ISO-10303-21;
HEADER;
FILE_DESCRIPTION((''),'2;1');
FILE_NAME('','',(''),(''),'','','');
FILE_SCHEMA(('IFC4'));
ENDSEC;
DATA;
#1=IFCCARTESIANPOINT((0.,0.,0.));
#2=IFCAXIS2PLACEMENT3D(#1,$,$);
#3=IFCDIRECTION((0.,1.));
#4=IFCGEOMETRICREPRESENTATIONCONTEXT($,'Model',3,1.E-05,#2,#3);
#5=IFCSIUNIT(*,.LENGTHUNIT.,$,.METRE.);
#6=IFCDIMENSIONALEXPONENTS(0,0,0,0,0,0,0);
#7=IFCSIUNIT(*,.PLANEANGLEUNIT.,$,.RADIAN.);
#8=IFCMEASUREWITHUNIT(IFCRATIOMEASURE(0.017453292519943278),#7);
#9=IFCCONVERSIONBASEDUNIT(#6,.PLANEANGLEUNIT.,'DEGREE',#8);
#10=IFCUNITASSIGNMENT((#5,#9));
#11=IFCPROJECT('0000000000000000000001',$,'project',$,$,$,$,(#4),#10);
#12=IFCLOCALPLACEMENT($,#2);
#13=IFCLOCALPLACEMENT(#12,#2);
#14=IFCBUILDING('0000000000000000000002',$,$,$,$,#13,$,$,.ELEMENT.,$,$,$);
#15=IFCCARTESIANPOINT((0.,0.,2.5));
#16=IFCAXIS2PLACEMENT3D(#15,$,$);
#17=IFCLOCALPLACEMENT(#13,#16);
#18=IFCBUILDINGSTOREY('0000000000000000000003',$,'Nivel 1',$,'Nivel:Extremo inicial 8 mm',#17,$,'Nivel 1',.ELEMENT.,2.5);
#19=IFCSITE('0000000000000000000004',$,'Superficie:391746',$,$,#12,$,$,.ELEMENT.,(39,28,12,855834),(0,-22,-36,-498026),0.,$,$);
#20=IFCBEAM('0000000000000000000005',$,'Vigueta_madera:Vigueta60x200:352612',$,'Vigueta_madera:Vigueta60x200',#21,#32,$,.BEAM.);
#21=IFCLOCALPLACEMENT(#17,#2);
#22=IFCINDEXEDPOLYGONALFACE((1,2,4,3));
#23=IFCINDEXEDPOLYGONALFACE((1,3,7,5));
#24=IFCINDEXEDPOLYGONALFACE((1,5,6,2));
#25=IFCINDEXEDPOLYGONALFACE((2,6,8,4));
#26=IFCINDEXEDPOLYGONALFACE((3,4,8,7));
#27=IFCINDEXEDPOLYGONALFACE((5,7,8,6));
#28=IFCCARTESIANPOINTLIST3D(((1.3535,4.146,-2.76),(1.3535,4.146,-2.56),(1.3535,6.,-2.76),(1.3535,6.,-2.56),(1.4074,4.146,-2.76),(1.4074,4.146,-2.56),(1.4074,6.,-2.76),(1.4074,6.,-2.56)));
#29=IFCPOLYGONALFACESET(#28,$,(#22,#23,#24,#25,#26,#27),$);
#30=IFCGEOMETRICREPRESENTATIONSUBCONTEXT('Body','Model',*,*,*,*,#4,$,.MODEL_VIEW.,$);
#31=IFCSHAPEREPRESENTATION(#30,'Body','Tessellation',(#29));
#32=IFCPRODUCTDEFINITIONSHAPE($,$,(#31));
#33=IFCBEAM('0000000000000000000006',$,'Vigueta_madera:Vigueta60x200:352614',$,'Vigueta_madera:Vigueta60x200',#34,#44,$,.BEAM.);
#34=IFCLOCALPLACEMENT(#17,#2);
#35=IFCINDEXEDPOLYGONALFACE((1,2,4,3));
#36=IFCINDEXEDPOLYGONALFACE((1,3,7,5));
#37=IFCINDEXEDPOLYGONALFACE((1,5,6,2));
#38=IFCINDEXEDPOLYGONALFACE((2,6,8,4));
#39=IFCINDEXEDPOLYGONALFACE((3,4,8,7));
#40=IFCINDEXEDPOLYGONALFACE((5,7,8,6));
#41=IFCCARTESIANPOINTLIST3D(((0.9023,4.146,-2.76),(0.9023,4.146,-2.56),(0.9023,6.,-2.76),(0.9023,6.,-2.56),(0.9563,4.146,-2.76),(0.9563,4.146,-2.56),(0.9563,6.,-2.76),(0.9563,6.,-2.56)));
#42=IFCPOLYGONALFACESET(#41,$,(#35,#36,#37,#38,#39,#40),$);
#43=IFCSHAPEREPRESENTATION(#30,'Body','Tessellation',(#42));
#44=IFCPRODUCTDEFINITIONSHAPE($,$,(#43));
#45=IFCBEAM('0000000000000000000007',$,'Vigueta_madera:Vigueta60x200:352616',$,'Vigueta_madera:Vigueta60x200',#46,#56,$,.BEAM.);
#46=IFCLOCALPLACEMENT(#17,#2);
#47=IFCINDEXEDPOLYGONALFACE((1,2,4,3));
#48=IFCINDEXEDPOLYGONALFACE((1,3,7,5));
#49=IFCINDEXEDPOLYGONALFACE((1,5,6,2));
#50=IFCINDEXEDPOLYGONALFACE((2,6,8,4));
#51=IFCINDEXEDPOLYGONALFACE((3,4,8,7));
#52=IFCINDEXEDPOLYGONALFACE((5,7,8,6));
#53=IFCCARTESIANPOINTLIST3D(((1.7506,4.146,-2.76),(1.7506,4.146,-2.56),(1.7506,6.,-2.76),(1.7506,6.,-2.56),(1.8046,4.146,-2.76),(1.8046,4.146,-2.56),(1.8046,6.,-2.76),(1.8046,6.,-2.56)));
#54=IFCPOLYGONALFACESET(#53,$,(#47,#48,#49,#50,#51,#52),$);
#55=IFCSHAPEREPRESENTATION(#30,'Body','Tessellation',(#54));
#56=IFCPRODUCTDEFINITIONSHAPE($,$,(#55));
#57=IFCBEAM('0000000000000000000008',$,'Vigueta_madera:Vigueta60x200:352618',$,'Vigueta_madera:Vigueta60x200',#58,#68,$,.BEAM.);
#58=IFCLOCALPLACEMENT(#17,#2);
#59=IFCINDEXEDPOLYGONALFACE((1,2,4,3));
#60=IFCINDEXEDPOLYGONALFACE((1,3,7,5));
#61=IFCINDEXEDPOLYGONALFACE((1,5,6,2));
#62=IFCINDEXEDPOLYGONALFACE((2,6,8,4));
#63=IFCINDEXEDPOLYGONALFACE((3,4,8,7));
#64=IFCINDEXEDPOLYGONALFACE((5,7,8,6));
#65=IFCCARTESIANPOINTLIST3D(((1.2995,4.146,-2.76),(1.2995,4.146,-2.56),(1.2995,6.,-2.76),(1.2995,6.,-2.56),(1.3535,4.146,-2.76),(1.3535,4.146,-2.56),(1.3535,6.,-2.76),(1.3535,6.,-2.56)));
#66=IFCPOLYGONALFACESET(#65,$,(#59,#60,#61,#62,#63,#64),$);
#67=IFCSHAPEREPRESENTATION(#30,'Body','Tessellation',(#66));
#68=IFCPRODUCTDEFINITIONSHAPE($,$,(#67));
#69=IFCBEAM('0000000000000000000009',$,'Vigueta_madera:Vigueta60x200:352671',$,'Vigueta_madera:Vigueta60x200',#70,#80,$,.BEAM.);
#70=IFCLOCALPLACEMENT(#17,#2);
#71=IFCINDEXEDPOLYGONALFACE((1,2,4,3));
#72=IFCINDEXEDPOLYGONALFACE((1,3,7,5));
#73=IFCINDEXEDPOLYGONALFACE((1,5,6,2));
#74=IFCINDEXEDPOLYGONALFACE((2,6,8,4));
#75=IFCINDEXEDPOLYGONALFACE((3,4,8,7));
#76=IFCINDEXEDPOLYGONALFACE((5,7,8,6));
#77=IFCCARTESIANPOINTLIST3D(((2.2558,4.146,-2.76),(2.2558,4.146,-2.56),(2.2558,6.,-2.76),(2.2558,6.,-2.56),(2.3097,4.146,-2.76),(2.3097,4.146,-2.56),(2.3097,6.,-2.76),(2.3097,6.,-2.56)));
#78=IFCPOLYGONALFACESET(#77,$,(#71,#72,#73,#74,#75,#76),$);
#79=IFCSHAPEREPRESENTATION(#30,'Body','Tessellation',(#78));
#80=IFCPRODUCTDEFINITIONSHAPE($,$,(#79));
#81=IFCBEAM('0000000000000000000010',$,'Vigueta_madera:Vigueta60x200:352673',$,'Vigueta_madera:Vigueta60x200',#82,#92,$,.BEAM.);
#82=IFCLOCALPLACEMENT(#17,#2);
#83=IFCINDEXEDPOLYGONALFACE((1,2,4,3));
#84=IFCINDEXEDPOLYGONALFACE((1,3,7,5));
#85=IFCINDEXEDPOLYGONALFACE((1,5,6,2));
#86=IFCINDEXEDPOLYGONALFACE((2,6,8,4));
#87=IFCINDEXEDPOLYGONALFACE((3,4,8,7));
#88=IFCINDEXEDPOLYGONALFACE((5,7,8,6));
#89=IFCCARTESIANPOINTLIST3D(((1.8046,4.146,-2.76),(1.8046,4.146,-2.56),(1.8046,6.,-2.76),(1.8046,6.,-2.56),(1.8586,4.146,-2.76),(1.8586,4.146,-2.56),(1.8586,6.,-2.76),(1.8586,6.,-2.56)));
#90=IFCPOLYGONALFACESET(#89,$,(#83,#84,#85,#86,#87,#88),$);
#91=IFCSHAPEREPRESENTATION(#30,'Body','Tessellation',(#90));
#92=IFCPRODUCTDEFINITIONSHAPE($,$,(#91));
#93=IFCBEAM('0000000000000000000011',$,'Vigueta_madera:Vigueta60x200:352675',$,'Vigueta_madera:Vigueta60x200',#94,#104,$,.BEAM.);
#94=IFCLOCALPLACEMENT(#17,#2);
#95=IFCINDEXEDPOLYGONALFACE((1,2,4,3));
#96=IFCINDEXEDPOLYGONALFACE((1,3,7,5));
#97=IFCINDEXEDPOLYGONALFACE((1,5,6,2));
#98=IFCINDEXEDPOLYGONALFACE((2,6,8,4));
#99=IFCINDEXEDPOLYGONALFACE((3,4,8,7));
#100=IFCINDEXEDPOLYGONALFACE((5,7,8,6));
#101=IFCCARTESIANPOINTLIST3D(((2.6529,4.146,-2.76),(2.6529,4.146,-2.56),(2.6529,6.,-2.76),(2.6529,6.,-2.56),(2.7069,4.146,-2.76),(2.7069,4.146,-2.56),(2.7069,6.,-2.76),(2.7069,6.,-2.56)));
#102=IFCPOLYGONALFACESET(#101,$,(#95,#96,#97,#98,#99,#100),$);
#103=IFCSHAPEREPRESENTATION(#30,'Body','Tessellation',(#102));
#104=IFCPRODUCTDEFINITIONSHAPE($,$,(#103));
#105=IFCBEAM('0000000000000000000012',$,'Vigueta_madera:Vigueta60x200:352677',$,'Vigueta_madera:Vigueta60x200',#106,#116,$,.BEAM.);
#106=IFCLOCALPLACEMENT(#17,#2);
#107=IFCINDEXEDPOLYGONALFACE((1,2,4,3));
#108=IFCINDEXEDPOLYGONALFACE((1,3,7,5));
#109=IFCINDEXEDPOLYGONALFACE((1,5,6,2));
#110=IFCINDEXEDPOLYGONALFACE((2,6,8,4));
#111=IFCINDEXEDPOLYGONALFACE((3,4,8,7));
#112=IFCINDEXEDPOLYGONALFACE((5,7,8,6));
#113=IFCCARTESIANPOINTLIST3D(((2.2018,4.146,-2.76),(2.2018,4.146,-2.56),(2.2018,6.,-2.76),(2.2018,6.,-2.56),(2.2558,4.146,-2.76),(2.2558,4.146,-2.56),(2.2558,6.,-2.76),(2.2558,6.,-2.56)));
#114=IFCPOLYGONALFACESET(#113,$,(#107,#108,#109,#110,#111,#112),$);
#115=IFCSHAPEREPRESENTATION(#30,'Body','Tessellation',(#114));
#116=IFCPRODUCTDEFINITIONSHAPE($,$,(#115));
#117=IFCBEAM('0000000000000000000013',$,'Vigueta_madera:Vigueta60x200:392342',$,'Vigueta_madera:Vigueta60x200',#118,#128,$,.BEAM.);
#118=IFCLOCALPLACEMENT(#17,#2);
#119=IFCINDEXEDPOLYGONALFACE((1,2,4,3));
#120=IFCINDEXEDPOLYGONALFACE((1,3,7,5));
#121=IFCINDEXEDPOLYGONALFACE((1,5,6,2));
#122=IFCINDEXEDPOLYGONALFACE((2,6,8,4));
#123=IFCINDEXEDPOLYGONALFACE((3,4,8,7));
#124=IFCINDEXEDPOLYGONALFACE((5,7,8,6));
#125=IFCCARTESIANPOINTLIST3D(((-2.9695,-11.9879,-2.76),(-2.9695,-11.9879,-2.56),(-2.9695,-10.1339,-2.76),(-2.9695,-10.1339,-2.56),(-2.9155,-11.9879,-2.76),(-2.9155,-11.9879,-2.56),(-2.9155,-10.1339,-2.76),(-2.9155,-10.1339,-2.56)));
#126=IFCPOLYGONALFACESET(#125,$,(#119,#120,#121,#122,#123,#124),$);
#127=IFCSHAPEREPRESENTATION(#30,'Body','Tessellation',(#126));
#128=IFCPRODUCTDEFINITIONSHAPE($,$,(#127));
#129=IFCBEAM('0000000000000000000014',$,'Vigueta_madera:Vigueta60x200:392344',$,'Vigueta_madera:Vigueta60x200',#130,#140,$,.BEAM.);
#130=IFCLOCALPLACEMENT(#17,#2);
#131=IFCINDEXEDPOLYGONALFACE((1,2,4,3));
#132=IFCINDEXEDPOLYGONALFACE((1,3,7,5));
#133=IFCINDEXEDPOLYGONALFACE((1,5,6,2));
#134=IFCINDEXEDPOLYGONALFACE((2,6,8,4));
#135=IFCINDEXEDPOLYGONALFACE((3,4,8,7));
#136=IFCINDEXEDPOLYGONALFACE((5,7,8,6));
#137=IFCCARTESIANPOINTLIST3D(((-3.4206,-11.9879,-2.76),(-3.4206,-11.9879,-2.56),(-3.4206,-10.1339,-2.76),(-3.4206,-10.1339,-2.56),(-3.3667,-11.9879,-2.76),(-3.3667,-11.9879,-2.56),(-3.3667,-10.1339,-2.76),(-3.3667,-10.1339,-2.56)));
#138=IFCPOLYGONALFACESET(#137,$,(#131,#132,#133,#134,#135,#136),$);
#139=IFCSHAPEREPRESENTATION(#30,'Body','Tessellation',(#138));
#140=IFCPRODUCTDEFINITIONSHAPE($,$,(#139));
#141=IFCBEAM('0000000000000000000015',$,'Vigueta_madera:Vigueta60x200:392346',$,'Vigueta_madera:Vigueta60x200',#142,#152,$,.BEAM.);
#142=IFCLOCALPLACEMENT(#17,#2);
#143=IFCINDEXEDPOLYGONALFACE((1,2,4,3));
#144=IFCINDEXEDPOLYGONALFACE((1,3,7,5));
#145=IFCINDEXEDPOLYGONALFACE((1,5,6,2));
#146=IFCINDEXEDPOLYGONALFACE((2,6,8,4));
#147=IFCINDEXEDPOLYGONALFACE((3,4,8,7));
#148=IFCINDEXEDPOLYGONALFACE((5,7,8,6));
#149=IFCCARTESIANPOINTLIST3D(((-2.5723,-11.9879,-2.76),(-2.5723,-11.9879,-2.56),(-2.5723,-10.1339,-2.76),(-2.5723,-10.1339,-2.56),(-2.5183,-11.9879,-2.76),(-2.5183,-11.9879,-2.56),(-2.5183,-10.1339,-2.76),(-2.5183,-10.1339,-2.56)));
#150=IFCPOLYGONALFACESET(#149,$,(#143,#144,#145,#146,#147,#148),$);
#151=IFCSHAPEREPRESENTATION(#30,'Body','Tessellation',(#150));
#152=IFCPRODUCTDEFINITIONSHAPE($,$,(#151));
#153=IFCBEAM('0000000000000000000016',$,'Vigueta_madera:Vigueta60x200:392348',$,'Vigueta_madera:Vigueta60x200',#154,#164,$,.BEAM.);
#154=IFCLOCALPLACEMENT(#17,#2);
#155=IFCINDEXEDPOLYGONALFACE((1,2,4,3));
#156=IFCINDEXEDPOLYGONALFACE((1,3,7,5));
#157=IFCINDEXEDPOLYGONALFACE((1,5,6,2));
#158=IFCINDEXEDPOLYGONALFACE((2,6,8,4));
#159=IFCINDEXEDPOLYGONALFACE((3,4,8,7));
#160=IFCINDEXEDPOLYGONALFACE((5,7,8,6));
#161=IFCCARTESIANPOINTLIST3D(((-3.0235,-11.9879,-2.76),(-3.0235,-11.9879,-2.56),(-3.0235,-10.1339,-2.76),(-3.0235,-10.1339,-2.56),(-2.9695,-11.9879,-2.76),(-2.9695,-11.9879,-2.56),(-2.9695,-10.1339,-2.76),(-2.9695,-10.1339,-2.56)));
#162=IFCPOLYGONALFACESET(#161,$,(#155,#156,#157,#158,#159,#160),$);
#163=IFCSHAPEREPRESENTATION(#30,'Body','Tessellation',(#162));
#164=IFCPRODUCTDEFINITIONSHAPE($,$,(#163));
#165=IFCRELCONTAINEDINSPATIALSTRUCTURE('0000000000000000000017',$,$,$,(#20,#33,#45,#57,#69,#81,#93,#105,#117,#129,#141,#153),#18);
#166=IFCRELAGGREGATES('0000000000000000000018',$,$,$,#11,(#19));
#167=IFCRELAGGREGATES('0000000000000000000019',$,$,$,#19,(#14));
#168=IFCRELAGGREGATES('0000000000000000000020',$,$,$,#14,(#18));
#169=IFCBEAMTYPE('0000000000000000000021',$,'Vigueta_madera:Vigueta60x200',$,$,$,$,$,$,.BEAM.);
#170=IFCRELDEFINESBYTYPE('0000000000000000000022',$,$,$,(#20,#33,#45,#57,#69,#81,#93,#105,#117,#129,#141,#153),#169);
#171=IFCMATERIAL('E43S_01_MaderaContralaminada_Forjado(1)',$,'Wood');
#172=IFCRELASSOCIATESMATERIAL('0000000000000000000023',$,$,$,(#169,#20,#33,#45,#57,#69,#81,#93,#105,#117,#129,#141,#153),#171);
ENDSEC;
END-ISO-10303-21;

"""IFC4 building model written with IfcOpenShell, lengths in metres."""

from ifc_helpers import new_model, entity, si_unit, converted_unit, direction, frame, frame_2d, origin, place, context, subcontext, project, spatial, polyline, segment, composite_curve, rectangle, outline, extrude, source, transform, mapped, material, material_profile, profile_set, profile_usage, type_object, type_shapes, element, save


model = new_model("IFC4")

# Units and contexts
model_context = context("Model", 3, precision=1e-05, world=origin(), true_north=direction((0.0, 1.0)))
body_context = subcontext(model_context, "Body", "Model", "MODEL_VIEW")
ifc_project = project(units=[si_unit("LENGTHUNIT", "METRE"), converted_unit("PLANEANGLEUNIT", "DEGREE", entity("IfcRatioMeasure", 0.017453292519943278), si_unit("PLANEANGLEUNIT", "RADIAN"), dimensions=[0, 0, 0, 0, 0, 0, 0])], contexts=[model_context])

# Site, building, storey
site_placement = place(None, origin())
site = spatial("IfcSite", under=ifc_project, at=site_placement, Name="Superficie:391746", CompositionType="ELEMENT", RefLatitude=(39, 28, 12, 855834), RefLongitude=(0, -22, -36, -498026), RefElevation=0.0)
building_placement = place(site_placement, origin())
building = spatial("IfcBuilding", under=site, at=building_placement, CompositionType="ELEMENT")
storey_placement = place(building_placement, frame((0.0, 0.0, 2.5)))
storey = spatial("IfcBuildingStorey", under=building, at=storey_placement, Name="Nivel 1", ObjectType="Nivel:Extremo inicial 8 mm", LongName="Nivel 1", CompositionType="ELEMENT", Elevation=2.5)

# Beams
ifc_material = material(Name="E43S_01_MaderaContralaminada_Forjado(1)", Category="Wood")
ifc_material_profile_1 = material_profile(ifc_material, outline(composite_curve([segment(polyline([(-0.027, -0.1, 0.0), (-0.027, 0.1, 0.0)]), True, "CONTINUOUS"), segment(polyline([(-0.027, 0.1, 0.0), (0.027, 0.1, 0.0)]), True, "CONTINUOUS"), segment(polyline([(0.027, 0.1, 0.0), (0.027, -0.1, 0.0)]), True, "CONTINUOUS"), segment(polyline([(0.027, -0.1, 0.0), (-0.027, -0.1, 0.0)]), True, "CONTINUOUS")], self_intersect=False), kind="CURVE"), Name="Vigueta60x200")
ifc_material_profile_2 = material_profile(ifc_material, outline(composite_curve([segment(polyline([(0.927, -0.027, -0.1), (0.927, -0.027, 0.1)]), True, "CONTINUOUS"), segment(polyline([(0.927, -0.027, 0.1), (-0.927, -0.027, 0.1)]), True, "CONTINUOUS"), segment(polyline([(-0.927, -0.027, 0.1), (-0.927, -0.027, -0.1)]), True, "CONTINUOUS"), segment(polyline([(-0.927, -0.027, -0.1), (0.927, -0.027, -0.1)]), True, "CONTINUOUS")], self_intersect=False), kind="CURVE"), Name="Vigueta60x200")
ifc_profile_set = profile_set([ifc_material_profile_1, ifc_material_profile_2], Name="Vigueta60x200")
ifc_profile_usage_1 = profile_usage(ifc_profile_set, cardinal=8)
beam_type = type_object("IfcBeamType", Name="Vigueta_madera:Vigueta60x200", PredefinedType="BEAM", material=ifc_profile_set)
shared_shape = source(origin(), body_context, "Body", "SweptSolid", [
    extrude(rectangle(XDim=0.2, YDim=0.054, at=frame_2d((0.0, 0.0), x_axis=(1.0, 0.0))), frame((-0.927, 0.0, 0.0), z_axis=(1.0, 0.0, 0.0), x_axis=(0.0, 0.0, -1.0)), (0.0, 0.0, 1.0), 1.854),
])
type_shapes(beam_type, [shared_shape])
beam_1_placement = place(storey_placement, frame((1.3804, 5.073, -2.66), z_axis=(0.0, 0.0, 1.0), x_axis=(0.0, 1.0, 0.0)))
element("IfcBeam", 1, at=beam_1_placement, inside=storey, type_object=beam_type, material=ifc_profile_usage_1, Name="Vigueta_madera:Vigueta60x200:352612", ObjectType="Vigueta_madera:Vigueta60x200", PredefinedType="BEAM", context=body_context, shape_type="MappedRepresentation", body=[
    mapped(shared_shape, transform((0.0, 0.0, 0.0), scale=1.0)),
])
ifc_profile_usage_2 = profile_usage(ifc_profile_set, cardinal=8)
beam_2_placement = place(storey_placement, frame((0.9293, 5.073, -2.66), z_axis=(0.0, 0.0, 1.0), x_axis=(0.0, 1.0, 0.0)))
element("IfcBeam", 2, at=beam_2_placement, inside=storey, type_object=beam_type, material=ifc_profile_usage_2, Name="Vigueta_madera:Vigueta60x200:352614", ObjectType="Vigueta_madera:Vigueta60x200", PredefinedType="BEAM", context=body_context, shape_type="MappedRepresentation", body=[
    mapped(shared_shape, transform((0.0, 0.0, 0.0), scale=1.0)),
])
ifc_profile_usage_3 = profile_usage(ifc_profile_set, cardinal=8)
beam_3_placement = place(storey_placement, frame((1.7776, 5.073, -2.66), z_axis=(0.0, 0.0, 1.0), x_axis=(0.0, 1.0, 0.0)))
element("IfcBeam", 3, at=beam_3_placement, inside=storey, type_object=beam_type, material=ifc_profile_usage_3, Name="Vigueta_madera:Vigueta60x200:352616", ObjectType="Vigueta_madera:Vigueta60x200", PredefinedType="BEAM", context=body_context, shape_type="MappedRepresentation", body=[
    mapped(shared_shape, transform((0.0, 0.0, 0.0), scale=1.0)),
])
ifc_profile_usage_4 = profile_usage(ifc_profile_set, cardinal=8)
beam_4_placement = place(storey_placement, frame((1.3265, 5.073, -2.66), z_axis=(0.0, 0.0, 1.0), x_axis=(0.0, 1.0, 0.0)))
element("IfcBeam", 4, at=beam_4_placement, inside=storey, type_object=beam_type, material=ifc_profile_usage_4, Name="Vigueta_madera:Vigueta60x200:352618", ObjectType="Vigueta_madera:Vigueta60x200", PredefinedType="BEAM", context=body_context, shape_type="MappedRepresentation", body=[
    mapped(shared_shape, transform((0.0, 0.0, 0.0), scale=1.0)),
])
ifc_profile_usage_5 = profile_usage(ifc_profile_set, cardinal=8)
beam_5_placement = place(storey_placement, frame((2.2827, 5.073, -2.66), z_axis=(0.0, 0.0, 1.0), x_axis=(0.0, 1.0, 0.0)))
element("IfcBeam", 5, at=beam_5_placement, inside=storey, type_object=beam_type, material=ifc_profile_usage_5, Name="Vigueta_madera:Vigueta60x200:352671", ObjectType="Vigueta_madera:Vigueta60x200", PredefinedType="BEAM", context=body_context, shape_type="MappedRepresentation", body=[
    mapped(shared_shape, transform((0.0, 0.0, 0.0), scale=1.0)),
])
ifc_profile_usage_6 = profile_usage(ifc_profile_set, cardinal=8)
beam_6_placement = place(storey_placement, frame((1.8316, 5.073, -2.66), z_axis=(0.0, 0.0, 1.0), x_axis=(0.0, 1.0, 0.0)))
element("IfcBeam", 6, at=beam_6_placement, inside=storey, type_object=beam_type, material=ifc_profile_usage_6, Name="Vigueta_madera:Vigueta60x200:352673", ObjectType="Vigueta_madera:Vigueta60x200", PredefinedType="BEAM", context=body_context, shape_type="MappedRepresentation", body=[
    mapped(shared_shape, transform((0.0, 0.0, 0.0), scale=1.0)),
])
ifc_profile_usage_7 = profile_usage(ifc_profile_set, cardinal=8)
beam_7_placement = place(storey_placement, frame((2.6799, 5.073, -2.66), z_axis=(0.0, 0.0, 1.0), x_axis=(0.0, 1.0, 0.0)))
element("IfcBeam", 7, at=beam_7_placement, inside=storey, type_object=beam_type, material=ifc_profile_usage_7, Name="Vigueta_madera:Vigueta60x200:352675", ObjectType="Vigueta_madera:Vigueta60x200", PredefinedType="BEAM", context=body_context, shape_type="MappedRepresentation", body=[
    mapped(shared_shape, transform((0.0, 0.0, 0.0), scale=1.0)),
])
ifc_profile_usage_8 = profile_usage(ifc_profile_set, cardinal=8)
beam_8_placement = place(storey_placement, frame((2.2288, 5.073, -2.66), z_axis=(0.0, 0.0, 1.0), x_axis=(0.0, 1.0, 0.0)))
element("IfcBeam", 8, at=beam_8_placement, inside=storey, type_object=beam_type, material=ifc_profile_usage_8, Name="Vigueta_madera:Vigueta60x200:352677", ObjectType="Vigueta_madera:Vigueta60x200", PredefinedType="BEAM", context=body_context, shape_type="MappedRepresentation", body=[
    mapped(shared_shape, transform((0.0, 0.0, 0.0), scale=1.0)),
])
ifc_profile_usage_9 = profile_usage(ifc_profile_set, cardinal=8)
beam_9_placement = place(storey_placement, frame((-2.9425, -11.0609, -2.66), z_axis=(0.0, 0.0, 1.0), x_axis=(0.0, 1.0, 0.0)))
element("IfcBeam", 9, at=beam_9_placement, inside=storey, type_object=beam_type, material=ifc_profile_usage_9, Name="Vigueta_madera:Vigueta60x200:392342", ObjectType="Vigueta_madera:Vigueta60x200", PredefinedType="BEAM", context=body_context, shape_type="MappedRepresentation", body=[
    mapped(shared_shape, transform((0.0, 0.0, 0.0), scale=1.0)),
])
ifc_profile_usage_10 = profile_usage(ifc_profile_set, cardinal=8)
beam_10_placement = place(storey_placement, frame((-3.3936, -11.0609, -2.66), z_axis=(0.0, 0.0, 1.0), x_axis=(0.0, 1.0, 0.0)))
element("IfcBeam", 10, at=beam_10_placement, inside=storey, type_object=beam_type, material=ifc_profile_usage_10, Name="Vigueta_madera:Vigueta60x200:392344", ObjectType="Vigueta_madera:Vigueta60x200", PredefinedType="BEAM", context=body_context, shape_type="MappedRepresentation", body=[
    mapped(shared_shape, transform((0.0, 0.0, 0.0), scale=1.0)),
])
ifc_profile_usage_11 = profile_usage(ifc_profile_set, cardinal=8)
beam_11_placement = place(storey_placement, frame((-2.5453, -11.0609, -2.66), z_axis=(0.0, 0.0, 1.0), x_axis=(0.0, 1.0, 0.0)))
element("IfcBeam", 11, at=beam_11_placement, inside=storey, type_object=beam_type, material=ifc_profile_usage_11, Name="Vigueta_madera:Vigueta60x200:392346", ObjectType="Vigueta_madera:Vigueta60x200", PredefinedType="BEAM", context=body_context, shape_type="MappedRepresentation", body=[
    mapped(shared_shape, transform((0.0, 0.0, 0.0), scale=1.0)),
])
ifc_profile_usage_12 = profile_usage(ifc_profile_set, cardinal=8)
beam_12_placement = place(storey_placement, frame((-2.9965, -11.0609, -2.66), z_axis=(0.0, 0.0, 1.0), x_axis=(0.0, 1.0, 0.0)))
element("IfcBeam", 12, at=beam_12_placement, inside=storey, type_object=beam_type, material=ifc_profile_usage_12, Name="Vigueta_madera:Vigueta60x200:392348", ObjectType="Vigueta_madera:Vigueta60x200", PredefinedType="BEAM", context=body_context, shape_type="MappedRepresentation", body=[
    mapped(shared_shape, transform((0.0, 0.0, 0.0), scale=1.0)),
])

save(model, "model.ifc")
